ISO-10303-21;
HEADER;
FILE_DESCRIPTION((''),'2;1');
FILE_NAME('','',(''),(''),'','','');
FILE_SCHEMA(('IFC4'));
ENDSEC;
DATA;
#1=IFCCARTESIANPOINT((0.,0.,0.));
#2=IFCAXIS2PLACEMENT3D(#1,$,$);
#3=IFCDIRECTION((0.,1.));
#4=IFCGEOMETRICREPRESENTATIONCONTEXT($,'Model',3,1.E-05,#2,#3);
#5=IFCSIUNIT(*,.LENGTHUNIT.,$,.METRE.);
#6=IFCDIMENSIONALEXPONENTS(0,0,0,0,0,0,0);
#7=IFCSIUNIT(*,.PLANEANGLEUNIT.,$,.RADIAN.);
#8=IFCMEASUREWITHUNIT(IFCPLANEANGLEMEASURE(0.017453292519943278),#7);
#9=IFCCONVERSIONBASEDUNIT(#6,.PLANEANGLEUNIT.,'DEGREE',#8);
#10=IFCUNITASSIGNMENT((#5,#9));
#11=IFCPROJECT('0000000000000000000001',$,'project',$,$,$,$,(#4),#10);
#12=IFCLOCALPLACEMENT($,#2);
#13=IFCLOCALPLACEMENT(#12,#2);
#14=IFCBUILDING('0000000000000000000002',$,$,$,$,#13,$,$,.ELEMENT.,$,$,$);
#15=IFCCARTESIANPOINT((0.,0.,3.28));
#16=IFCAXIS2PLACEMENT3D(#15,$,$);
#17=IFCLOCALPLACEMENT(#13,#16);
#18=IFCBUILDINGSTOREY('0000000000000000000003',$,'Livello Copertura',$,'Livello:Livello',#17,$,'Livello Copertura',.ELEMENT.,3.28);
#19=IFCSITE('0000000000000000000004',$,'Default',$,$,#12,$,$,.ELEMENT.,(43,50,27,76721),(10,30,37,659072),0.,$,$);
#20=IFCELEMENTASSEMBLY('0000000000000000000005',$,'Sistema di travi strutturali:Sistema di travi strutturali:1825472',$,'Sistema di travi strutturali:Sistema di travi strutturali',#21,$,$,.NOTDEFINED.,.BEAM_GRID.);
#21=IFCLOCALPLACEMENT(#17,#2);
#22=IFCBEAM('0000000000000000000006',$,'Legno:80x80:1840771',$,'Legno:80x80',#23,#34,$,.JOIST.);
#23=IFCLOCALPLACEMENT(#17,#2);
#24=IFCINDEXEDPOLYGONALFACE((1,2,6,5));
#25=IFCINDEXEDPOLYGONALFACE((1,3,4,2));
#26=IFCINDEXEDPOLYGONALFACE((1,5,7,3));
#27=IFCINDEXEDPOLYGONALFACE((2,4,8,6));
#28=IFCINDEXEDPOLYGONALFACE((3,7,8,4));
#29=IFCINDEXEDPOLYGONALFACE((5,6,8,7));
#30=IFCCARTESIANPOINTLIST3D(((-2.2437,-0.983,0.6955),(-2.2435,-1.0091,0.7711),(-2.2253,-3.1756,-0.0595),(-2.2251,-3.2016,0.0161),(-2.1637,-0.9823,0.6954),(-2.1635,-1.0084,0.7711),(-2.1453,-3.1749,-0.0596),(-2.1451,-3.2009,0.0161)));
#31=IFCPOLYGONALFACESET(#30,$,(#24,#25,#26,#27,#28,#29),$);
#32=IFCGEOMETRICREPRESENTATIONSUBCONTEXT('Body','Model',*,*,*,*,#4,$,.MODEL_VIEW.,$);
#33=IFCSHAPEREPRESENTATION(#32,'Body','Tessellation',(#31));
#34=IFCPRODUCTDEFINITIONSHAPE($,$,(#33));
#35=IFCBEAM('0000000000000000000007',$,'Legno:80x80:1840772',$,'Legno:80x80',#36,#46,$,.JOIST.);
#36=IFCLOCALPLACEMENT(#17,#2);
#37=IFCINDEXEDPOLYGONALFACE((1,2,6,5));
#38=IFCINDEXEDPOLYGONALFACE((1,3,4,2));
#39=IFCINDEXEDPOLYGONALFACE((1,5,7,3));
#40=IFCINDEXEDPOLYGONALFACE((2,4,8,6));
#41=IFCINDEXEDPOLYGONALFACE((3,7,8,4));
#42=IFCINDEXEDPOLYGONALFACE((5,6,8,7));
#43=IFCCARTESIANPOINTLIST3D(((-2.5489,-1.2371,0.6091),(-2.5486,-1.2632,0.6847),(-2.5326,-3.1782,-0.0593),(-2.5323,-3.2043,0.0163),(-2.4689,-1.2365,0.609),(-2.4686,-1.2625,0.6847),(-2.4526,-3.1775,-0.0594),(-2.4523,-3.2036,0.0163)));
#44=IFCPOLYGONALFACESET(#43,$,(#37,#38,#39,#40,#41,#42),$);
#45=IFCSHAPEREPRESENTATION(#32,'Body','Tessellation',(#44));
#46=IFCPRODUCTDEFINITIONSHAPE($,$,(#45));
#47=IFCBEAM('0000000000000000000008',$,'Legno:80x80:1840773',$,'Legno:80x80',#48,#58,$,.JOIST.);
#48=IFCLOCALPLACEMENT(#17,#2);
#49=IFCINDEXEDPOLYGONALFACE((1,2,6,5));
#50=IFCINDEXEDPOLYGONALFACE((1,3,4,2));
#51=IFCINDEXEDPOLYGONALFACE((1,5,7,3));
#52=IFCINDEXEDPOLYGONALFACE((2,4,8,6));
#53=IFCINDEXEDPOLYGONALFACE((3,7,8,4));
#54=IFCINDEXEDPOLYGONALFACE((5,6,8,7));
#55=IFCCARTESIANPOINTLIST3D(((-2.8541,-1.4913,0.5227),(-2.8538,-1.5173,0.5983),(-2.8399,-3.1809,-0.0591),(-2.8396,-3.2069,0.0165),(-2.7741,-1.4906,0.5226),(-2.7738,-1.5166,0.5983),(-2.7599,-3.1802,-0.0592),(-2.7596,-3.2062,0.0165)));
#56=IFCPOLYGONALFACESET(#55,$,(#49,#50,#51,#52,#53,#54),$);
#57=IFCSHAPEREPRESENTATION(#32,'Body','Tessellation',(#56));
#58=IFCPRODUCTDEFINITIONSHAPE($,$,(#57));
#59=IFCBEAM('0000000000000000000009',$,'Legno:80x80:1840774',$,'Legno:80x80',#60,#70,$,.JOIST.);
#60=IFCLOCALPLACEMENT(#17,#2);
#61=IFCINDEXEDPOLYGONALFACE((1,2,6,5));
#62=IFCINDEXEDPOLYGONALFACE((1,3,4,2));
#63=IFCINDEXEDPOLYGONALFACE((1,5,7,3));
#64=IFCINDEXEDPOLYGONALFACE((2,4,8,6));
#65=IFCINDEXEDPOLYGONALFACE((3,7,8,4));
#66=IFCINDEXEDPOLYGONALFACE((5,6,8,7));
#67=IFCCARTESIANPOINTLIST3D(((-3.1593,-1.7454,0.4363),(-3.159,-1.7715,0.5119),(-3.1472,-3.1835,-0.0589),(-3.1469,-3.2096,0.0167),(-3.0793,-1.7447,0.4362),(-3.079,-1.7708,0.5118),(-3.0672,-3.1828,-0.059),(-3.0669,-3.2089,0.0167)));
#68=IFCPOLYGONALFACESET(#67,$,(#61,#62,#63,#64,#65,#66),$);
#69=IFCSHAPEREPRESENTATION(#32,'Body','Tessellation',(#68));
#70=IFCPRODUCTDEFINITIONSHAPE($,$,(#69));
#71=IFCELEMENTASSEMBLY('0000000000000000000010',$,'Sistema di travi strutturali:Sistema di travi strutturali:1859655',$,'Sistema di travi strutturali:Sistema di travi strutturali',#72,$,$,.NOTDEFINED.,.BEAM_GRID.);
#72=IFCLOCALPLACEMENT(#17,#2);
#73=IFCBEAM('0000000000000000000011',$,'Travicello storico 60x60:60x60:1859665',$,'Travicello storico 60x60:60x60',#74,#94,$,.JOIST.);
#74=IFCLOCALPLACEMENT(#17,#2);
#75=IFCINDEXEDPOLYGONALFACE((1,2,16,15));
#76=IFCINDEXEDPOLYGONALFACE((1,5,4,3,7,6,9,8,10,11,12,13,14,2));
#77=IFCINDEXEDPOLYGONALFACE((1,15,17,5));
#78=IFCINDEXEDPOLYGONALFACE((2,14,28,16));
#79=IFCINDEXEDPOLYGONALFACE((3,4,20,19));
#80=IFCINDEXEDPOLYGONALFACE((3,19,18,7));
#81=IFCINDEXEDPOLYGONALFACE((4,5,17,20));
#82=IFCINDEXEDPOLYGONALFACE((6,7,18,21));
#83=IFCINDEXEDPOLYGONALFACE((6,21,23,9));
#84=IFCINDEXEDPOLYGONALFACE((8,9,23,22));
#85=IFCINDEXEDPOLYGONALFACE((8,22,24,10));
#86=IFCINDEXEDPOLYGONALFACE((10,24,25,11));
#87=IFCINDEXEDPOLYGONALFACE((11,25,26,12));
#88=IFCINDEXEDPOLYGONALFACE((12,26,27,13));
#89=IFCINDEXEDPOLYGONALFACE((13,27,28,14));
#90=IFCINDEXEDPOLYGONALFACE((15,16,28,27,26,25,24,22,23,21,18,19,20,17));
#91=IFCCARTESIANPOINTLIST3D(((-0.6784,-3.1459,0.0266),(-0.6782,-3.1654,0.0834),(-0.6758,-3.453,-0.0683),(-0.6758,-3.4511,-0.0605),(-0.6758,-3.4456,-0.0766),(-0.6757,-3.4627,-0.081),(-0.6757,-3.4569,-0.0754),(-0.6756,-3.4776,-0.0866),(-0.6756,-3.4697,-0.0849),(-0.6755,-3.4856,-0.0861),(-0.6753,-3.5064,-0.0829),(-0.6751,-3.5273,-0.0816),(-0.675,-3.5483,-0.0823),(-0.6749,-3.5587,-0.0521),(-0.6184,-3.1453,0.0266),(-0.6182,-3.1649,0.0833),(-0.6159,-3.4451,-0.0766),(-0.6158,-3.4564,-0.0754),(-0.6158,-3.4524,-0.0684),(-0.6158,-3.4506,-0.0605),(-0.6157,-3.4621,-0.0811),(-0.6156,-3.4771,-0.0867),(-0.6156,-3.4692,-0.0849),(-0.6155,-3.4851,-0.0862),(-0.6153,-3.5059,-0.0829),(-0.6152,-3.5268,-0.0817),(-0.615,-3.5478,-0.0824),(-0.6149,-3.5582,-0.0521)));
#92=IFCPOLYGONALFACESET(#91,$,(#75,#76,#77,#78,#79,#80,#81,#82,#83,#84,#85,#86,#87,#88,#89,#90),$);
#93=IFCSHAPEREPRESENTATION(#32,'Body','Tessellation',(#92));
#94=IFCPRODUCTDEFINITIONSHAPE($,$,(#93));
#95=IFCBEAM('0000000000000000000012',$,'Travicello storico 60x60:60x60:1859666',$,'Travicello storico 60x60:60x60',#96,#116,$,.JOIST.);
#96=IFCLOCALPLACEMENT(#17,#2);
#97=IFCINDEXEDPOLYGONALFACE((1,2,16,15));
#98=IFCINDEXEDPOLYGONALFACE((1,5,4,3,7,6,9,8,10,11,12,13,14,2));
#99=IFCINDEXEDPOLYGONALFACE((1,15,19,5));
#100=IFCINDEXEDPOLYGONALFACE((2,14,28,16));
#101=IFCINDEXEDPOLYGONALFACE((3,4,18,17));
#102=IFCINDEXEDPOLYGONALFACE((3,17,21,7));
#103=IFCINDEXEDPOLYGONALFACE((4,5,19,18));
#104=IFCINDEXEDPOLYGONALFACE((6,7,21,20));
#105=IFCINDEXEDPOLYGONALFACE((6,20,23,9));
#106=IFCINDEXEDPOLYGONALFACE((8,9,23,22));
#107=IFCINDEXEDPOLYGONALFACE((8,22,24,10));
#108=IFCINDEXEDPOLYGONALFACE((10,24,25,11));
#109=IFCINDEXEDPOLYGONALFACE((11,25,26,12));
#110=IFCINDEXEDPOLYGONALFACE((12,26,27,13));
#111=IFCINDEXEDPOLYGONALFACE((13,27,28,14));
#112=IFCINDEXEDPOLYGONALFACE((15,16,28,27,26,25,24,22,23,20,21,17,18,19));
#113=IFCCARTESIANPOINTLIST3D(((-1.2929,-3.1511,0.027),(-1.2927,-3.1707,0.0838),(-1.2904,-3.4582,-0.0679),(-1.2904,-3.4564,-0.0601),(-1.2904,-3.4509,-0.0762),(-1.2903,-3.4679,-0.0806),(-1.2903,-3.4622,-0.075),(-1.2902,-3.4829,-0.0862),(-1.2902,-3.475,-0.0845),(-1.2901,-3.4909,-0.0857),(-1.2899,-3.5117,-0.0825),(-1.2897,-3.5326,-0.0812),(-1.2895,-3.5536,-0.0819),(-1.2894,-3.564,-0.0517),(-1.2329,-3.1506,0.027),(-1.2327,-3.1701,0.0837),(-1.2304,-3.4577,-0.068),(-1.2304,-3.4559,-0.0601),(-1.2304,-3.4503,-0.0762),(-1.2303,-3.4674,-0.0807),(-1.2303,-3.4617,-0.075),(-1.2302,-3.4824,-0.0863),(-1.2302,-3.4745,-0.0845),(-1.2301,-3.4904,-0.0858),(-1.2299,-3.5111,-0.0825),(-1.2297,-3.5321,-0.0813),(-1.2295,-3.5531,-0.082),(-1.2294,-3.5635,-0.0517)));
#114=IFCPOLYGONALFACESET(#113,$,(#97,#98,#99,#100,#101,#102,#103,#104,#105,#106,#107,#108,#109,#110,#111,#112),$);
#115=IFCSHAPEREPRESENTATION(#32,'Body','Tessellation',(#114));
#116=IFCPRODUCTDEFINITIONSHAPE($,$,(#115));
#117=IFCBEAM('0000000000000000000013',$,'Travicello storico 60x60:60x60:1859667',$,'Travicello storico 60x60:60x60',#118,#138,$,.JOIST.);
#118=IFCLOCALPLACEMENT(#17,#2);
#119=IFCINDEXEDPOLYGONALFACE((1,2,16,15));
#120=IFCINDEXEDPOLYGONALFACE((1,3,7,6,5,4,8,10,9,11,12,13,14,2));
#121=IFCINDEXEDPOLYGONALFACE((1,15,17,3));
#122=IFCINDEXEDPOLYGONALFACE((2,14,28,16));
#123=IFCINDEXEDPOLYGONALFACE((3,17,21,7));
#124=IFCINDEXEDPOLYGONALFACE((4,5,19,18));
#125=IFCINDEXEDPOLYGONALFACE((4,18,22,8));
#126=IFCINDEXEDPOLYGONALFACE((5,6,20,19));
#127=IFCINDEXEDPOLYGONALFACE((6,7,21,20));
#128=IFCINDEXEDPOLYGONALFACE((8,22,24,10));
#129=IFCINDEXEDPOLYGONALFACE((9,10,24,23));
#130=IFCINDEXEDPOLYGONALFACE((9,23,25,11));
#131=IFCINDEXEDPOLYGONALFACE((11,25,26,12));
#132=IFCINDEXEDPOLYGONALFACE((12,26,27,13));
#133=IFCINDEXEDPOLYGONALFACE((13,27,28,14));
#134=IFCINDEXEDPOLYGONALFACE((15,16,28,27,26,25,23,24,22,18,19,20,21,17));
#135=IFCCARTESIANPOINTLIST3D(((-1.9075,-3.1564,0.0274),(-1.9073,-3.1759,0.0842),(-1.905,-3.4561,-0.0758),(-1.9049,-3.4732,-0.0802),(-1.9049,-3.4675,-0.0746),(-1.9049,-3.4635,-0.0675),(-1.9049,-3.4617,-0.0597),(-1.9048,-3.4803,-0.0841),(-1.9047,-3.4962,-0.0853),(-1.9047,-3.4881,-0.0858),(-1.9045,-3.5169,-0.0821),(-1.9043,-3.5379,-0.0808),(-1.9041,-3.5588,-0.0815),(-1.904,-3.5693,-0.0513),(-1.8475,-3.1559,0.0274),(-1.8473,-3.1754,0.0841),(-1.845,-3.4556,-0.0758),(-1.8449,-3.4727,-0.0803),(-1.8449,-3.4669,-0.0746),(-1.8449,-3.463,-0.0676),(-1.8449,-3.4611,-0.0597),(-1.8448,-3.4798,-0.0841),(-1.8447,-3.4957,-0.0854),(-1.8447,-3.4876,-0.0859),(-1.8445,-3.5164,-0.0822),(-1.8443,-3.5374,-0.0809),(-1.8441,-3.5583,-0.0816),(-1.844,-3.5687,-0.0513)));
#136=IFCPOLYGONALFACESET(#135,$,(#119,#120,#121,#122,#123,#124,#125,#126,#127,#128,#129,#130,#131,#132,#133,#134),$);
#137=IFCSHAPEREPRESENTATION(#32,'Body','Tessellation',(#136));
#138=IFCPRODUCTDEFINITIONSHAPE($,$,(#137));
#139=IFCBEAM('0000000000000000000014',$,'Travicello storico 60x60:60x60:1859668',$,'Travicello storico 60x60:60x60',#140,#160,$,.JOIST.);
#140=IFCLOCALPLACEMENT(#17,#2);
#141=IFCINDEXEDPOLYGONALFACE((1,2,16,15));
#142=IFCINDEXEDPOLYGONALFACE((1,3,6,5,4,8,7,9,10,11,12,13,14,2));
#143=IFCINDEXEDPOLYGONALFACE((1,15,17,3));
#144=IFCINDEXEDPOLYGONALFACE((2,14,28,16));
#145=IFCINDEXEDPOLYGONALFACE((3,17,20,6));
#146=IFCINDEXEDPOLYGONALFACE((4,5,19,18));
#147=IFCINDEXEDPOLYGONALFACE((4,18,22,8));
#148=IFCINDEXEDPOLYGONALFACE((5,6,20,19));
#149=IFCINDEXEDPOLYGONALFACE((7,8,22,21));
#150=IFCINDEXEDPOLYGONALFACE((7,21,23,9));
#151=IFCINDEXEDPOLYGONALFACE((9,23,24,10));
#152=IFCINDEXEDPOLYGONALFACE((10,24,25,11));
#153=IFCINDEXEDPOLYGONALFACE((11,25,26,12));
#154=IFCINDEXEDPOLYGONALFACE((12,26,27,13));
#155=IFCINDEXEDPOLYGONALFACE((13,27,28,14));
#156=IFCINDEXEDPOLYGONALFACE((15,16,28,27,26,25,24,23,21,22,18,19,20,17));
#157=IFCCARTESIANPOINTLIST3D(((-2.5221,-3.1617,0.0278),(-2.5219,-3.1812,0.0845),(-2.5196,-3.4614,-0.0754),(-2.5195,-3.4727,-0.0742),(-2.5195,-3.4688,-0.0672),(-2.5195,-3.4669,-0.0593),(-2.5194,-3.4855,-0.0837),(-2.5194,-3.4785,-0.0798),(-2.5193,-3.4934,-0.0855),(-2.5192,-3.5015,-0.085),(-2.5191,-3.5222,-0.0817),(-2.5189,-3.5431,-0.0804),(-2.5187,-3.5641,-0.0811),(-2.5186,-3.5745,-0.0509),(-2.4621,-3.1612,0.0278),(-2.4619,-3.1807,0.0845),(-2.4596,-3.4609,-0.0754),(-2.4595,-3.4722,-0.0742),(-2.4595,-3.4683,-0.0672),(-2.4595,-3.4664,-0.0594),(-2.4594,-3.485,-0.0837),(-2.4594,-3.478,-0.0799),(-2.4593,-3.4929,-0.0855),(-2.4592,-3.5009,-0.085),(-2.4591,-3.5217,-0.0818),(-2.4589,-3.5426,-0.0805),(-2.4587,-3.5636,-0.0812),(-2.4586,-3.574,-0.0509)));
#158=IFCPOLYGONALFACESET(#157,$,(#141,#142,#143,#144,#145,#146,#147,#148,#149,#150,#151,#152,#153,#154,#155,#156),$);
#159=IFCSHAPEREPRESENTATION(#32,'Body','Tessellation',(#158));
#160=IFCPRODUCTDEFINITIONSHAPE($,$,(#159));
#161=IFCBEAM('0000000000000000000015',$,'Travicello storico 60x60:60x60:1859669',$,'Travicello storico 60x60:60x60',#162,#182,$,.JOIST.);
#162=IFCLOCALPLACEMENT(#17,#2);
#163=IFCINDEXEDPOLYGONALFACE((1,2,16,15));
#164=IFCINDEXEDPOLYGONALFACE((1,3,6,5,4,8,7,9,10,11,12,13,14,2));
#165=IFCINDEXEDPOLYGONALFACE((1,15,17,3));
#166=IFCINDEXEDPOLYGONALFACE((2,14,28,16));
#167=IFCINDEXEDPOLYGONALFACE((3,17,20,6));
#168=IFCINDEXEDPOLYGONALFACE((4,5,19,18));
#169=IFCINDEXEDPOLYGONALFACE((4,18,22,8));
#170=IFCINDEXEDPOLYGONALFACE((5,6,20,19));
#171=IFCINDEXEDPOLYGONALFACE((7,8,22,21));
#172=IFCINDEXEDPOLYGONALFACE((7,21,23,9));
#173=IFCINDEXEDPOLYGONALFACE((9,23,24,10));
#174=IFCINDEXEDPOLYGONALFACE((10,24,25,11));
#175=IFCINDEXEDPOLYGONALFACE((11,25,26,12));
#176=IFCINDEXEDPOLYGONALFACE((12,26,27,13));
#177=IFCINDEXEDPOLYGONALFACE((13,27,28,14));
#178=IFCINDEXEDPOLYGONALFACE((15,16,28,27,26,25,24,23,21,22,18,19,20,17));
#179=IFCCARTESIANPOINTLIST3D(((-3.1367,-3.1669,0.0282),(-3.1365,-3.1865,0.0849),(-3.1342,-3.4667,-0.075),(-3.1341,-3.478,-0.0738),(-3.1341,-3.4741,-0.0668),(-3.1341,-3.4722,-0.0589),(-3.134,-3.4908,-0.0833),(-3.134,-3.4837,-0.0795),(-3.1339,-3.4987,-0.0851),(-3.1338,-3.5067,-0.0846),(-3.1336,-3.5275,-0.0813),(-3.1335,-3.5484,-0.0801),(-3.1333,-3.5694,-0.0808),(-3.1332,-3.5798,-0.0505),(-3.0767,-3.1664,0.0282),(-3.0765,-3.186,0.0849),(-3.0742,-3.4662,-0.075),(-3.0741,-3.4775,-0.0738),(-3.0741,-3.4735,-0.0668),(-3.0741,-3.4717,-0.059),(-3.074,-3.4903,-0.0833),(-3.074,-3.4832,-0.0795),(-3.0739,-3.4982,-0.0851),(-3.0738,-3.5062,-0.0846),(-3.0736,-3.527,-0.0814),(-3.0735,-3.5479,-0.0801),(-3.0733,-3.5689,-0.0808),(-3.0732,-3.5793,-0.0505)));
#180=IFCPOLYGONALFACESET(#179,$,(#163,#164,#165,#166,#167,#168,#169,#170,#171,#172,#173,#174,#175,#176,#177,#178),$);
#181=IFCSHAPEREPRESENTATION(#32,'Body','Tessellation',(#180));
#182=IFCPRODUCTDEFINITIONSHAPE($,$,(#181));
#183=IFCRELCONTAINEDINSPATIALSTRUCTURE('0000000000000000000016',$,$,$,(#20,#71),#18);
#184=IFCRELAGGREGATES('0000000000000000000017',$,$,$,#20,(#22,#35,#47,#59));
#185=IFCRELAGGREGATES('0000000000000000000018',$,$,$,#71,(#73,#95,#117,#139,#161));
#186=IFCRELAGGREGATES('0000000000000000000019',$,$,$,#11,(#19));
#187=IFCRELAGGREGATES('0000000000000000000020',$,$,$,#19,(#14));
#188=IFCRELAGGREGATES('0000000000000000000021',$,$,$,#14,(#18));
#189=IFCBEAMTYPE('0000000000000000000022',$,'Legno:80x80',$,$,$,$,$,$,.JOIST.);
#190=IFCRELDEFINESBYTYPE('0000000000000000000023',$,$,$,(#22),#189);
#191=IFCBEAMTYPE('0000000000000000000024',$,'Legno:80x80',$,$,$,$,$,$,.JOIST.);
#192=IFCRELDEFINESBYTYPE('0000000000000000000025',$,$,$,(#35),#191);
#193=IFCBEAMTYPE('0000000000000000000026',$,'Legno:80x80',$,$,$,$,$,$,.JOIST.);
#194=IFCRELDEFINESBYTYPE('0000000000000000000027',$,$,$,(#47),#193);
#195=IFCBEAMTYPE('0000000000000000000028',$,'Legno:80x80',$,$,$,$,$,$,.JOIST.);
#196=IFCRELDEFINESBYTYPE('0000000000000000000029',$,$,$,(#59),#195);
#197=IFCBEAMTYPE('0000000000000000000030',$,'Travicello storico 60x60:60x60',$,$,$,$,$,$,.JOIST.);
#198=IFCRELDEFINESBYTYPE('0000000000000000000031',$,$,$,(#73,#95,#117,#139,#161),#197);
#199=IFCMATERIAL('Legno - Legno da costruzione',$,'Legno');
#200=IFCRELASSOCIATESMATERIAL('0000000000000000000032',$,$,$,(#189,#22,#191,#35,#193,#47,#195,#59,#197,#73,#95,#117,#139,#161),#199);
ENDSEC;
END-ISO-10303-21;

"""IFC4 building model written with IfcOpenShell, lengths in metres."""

from ifc_helpers import new_model, entity, si_unit, converted_unit, direction, frame, origin, place, context, subcontext, project, spatial, line, arc, indexed_curve, outline, extrude, source, transform, mapped, material, type_object, type_shapes, element, aggregate, save


model = new_model("IFC4")

# Units and contexts
model_context = context("Model", 3, precision=1e-05, world=origin(), true_north=direction((0.0, 1.0)))
body_context = subcontext(model_context, "Body", "Model", "MODEL_VIEW")
ifc_project = project(units=[si_unit("LENGTHUNIT", "METRE"), converted_unit("PLANEANGLEUNIT", "DEGREE", entity("IfcPlaneAngleMeasure", 0.017453292519943278), si_unit("PLANEANGLEUNIT", "RADIAN"), dimensions=[0, 0, 0, 0, 0, 0, 0])], contexts=[model_context])

# Site, building, storey
site_placement = place(None, origin())
site = spatial("IfcSite", under=ifc_project, at=site_placement, Name="Default", CompositionType="ELEMENT", RefLatitude=(43, 50, 27, 76721), RefLongitude=(10, 30, 37, 659072), RefElevation=0.0)
building_placement = place(site_placement, origin())
building = spatial("IfcBuilding", under=site, at=building_placement, CompositionType="ELEMENT")
storey_placement = place(building_placement, frame((0.0, 0.0, 3.28)))
storey = spatial("IfcBuildingStorey", under=building, at=storey_placement, Name="Livello Copertura", ObjectType="Livello:Livello", LongName="Livello Copertura", CompositionType="ELEMENT", Elevation=3.28)

# Shared definitions
ifc_material = material(Name="Legno - Legno da costruzione", Category="Legno")

# Element assemblies, beams
assembly_1_placement = place(storey_placement, origin())
assembly_1 = element("IfcElementAssembly", 1, at=assembly_1_placement, inside=storey, Name="Sistema di travi strutturali:Sistema di travi strutturali:1825472", ObjectType="Sistema di travi strutturali:Sistema di travi strutturali", AssemblyPlace="NOTDEFINED", PredefinedType="BEAM_GRID")
beam_type_1 = type_object("IfcBeamType", Name="Legno:80x80", PredefinedType="JOIST", material=ifc_material)
shared_shape_1 = source(origin(), body_context, "Body", "SweptSolid", [
    extrude(outline(indexed_curve([(-1.1595, -0.04), (1.1595, -0.04), (1.1595, 0.04), (-1.1595, 0.04), (-1.1595, -0.04)], self_intersect=False)), frame((0.0, 0.0, -0.04), z_axis=(0.0, 0.0, 1.0), x_axis=(-1.0, 0.0, 0.0)), (0.0, 0.0, 1.0), 0.08),
])
type_shapes(beam_type_1, [shared_shape_1])
beam_1_placement = place(assembly_1_placement, frame((-2.1944, -2.092, 0.3558), z_axis=(0.003393, -0.32555, 0.945519), x_axis=(-0.007932, 0.945486, 0.325568)))
beam_1 = element("IfcBeam", 2, at=beam_1_placement, type_object=beam_type_1, material=ifc_material, Name="Legno:80x80:1840771", ObjectType="Legno:80x80", PredefinedType="JOIST", context=body_context, shape_type="MappedRepresentation", body=[
    mapped(shared_shape_1, transform((0.0, 0.0, 0.0), scale=1.0)),
])
beam_type_2 = type_object("IfcBeamType", Name="Legno:80x80", PredefinedType="JOIST", material=ifc_material)
shared_shape_2 = source(origin(), body_context, "Body", "SweptSolid", [
    extrude(outline(indexed_curve([(-1.0265, -0.04), (1.0265, -0.04), (1.0265, 0.04), (-1.0265, 0.04), (-1.0265, -0.04)], self_intersect=False)), frame((0.0, 0.0, -0.04), z_axis=(0.0, 0.0, 1.0), x_axis=(-1.0, 0.0, 0.0)), (0.0, 0.0, 1.0), 0.08),
])
type_shapes(beam_type_2, [shared_shape_2])
beam_2_placement = place(assembly_1_placement, frame((-2.5006, -2.2204, 0.3127), z_axis=(0.003393, -0.32555, 0.945519), x_axis=(-0.007932, 0.945486, 0.325568)))
beam_2 = element("IfcBeam", 3, at=beam_2_placement, type_object=beam_type_2, material=ifc_material, Name="Legno:80x80:1840772", ObjectType="Legno:80x80", PredefinedType="JOIST", context=body_context, shape_type="MappedRepresentation", body=[
    mapped(shared_shape_2, transform((0.0, 0.0, 0.0), scale=1.0)),
])
beam_type_3 = type_object("IfcBeamType", Name="Legno:80x80", PredefinedType="JOIST", material=ifc_material)
shared_shape_3 = source(origin(), body_context, "Body", "SweptSolid", [
    extrude(outline(indexed_curve([(-0.8935, -0.04), (0.8935, -0.04), (0.8935, 0.04), (-0.8935, 0.04), (-0.8935, -0.04)], self_intersect=False)), frame((0.0, 0.0, -0.04), z_axis=(0.0, 0.0, 1.0), x_axis=(-1.0, 0.0, 0.0)), (0.0, 0.0, 1.0), 0.08),
])
type_shapes(beam_type_3, [shared_shape_3])
beam_3_placement = place(assembly_1_placement, frame((-2.8069, -2.3488, 0.2696), z_axis=(0.003393, -0.32555, 0.945519), x_axis=(-0.007932, 0.945486, 0.325568)))
beam_3 = element("IfcBeam", 4, at=beam_3_placement, type_object=beam_type_3, material=ifc_material, Name="Legno:80x80:1840773", ObjectType="Legno:80x80", PredefinedType="JOIST", context=body_context, shape_type="MappedRepresentation", body=[
    mapped(shared_shape_3, transform((0.0, 0.0, 0.0), scale=1.0)),
])
beam_type_4 = type_object("IfcBeamType", Name="Legno:80x80", PredefinedType="JOIST", material=ifc_material)
shared_shape_4 = source(origin(), body_context, "Body", "SweptSolid", [
    extrude(outline(indexed_curve([(-0.7605, -0.04), (0.7605, -0.04), (0.7605, 0.04), (-0.7605, 0.04), (-0.7605, -0.04)], self_intersect=False)), frame((0.0, 0.0, -0.04), z_axis=(0.0, 0.0, 1.0), x_axis=(-1.0, 0.0, 0.0)), (0.0, 0.0, 1.0), 0.08),
])
type_shapes(beam_type_4, [shared_shape_4])
beam_4_placement = place(assembly_1_placement, frame((-3.1131, -2.4772, 0.2265), z_axis=(0.003393, -0.32555, 0.945519), x_axis=(-0.007932, 0.945486, 0.325568)))
beam_4 = element("IfcBeam", 5, at=beam_4_placement, type_object=beam_type_4, material=ifc_material, Name="Legno:80x80:1840774", ObjectType="Legno:80x80", PredefinedType="JOIST", context=body_context, shape_type="MappedRepresentation", body=[
    mapped(shared_shape_4, transform((0.0, 0.0, 0.0), scale=1.0)),
])
aggregate(assembly_1, [beam_1, beam_2, beam_3, beam_4])
assembly_2_placement = place(storey_placement, origin())
assembly_2 = element("IfcElementAssembly", 6, at=assembly_2_placement, inside=storey, Name="Sistema di travi strutturali:Sistema di travi strutturali:1859655", ObjectType="Sistema di travi strutturali:Sistema di travi strutturali", AssemblyPlace="NOTDEFINED", PredefinedType="BEAM_GRID")
beam_type_5 = type_object("IfcBeamType", Name="Travicello storico 60x60:60x60", PredefinedType="JOIST", material=ifc_material)
shared_shape_5 = source(origin(), body_context, "Body", "SweptSolid", [
    extrude(outline(indexed_curve([(-0.0359, -0.2606), (0.0241, -0.2606), (0.0241, 0.0564), (0.0071, 0.0564), (0.0228, 0.074), (0.0201, 0.0974), (0.0061, 0.1256), (-0.0039, 0.1554), (-0.0359, 0.1554)], segments=[line(1, 2, 3, 4), arc(4, 5, 6), arc(6, 7, 8), line(8, 9, 1)], self_intersect=False)), frame((0.0874, -0.03, -0.0059), z_axis=(0.0, 1.0, 0.0), x_axis=(0.0, 0.0, -1.0)), (0.0, 0.0, 1.0), 0.06),
])
type_shapes(beam_type_5, [shared_shape_5])
beam_5_placement = place(assembly_2_placement, frame((-0.6455, -3.4844, -0.0583), z_axis=(0.003393, -0.32555, 0.945519), x_axis=(-0.007932, 0.945486, 0.325568)))
beam_5 = element("IfcBeam", 7, at=beam_5_placement, type_object=beam_type_5, material=ifc_material, Name="Travicello storico 60x60:60x60:1859665", ObjectType="Travicello storico 60x60:60x60", PredefinedType="JOIST", context=body_context, shape_type="MappedRepresentation", body=[
    mapped(shared_shape_5, transform((0.0, 0.0, 0.0), scale=1.0)),
])
beam_6_placement = place(assembly_2_placement, frame((-1.2601, -3.4897, -0.0579), z_axis=(0.003393, -0.32555, 0.945519), x_axis=(-0.007932, 0.945486, 0.325568)))
beam_6 = element("IfcBeam", 8, at=beam_6_placement, type_object=beam_type_5, material=ifc_material, Name="Travicello storico 60x60:60x60:1859666", ObjectType="Travicello storico 60x60:60x60", PredefinedType="JOIST", context=body_context, shape_type="MappedRepresentation", body=[
    mapped(shared_shape_5, transform((0.0, 0.0, 0.0), scale=1.0)),
])
beam_7_placement = place(assembly_2_placement, frame((-1.8747, -3.4949, -0.0575), z_axis=(0.003393, -0.32555, 0.945519), x_axis=(-0.007932, 0.945486, 0.325568)))
beam_7 = element("IfcBeam", 9, at=beam_7_placement, type_object=beam_type_5, material=ifc_material, Name="Travicello storico 60x60:60x60:1859667", ObjectType="Travicello storico 60x60:60x60", PredefinedType="JOIST", context=body_context, shape_type="MappedRepresentation", body=[
    mapped(shared_shape_5, transform((0.0, 0.0, 0.0), scale=1.0)),
])
beam_8_placement = place(assembly_2_placement, frame((-2.4892, -3.5002, -0.0571), z_axis=(0.003393, -0.32555, 0.945519), x_axis=(-0.007932, 0.945486, 0.325568)))
beam_8 = element("IfcBeam", 10, at=beam_8_placement, type_object=beam_type_5, material=ifc_material, Name="Travicello storico 60x60:60x60:1859668", ObjectType="Travicello storico 60x60:60x60", PredefinedType="JOIST", context=body_context, shape_type="MappedRepresentation", body=[
    mapped(shared_shape_5, transform((0.0, 0.0, 0.0), scale=1.0)),
])
beam_9_placement = place(assembly_2_placement, frame((-3.1038, -3.5055, -0.0567), z_axis=(0.003393, -0.32555, 0.945519), x_axis=(-0.007932, 0.945486, 0.325568)))
beam_9 = element("IfcBeam", 11, at=beam_9_placement, type_object=beam_type_5, material=ifc_material, Name="Travicello storico 60x60:60x60:1859669", ObjectType="Travicello storico 60x60:60x60", PredefinedType="JOIST", context=body_context, shape_type="MappedRepresentation", body=[
    mapped(shared_shape_5, transform((0.0, 0.0, 0.0), scale=1.0)),
])
aggregate(assembly_2, [beam_5, beam_6, beam_7, beam_8, beam_9])

save(model, "model.ifc")
